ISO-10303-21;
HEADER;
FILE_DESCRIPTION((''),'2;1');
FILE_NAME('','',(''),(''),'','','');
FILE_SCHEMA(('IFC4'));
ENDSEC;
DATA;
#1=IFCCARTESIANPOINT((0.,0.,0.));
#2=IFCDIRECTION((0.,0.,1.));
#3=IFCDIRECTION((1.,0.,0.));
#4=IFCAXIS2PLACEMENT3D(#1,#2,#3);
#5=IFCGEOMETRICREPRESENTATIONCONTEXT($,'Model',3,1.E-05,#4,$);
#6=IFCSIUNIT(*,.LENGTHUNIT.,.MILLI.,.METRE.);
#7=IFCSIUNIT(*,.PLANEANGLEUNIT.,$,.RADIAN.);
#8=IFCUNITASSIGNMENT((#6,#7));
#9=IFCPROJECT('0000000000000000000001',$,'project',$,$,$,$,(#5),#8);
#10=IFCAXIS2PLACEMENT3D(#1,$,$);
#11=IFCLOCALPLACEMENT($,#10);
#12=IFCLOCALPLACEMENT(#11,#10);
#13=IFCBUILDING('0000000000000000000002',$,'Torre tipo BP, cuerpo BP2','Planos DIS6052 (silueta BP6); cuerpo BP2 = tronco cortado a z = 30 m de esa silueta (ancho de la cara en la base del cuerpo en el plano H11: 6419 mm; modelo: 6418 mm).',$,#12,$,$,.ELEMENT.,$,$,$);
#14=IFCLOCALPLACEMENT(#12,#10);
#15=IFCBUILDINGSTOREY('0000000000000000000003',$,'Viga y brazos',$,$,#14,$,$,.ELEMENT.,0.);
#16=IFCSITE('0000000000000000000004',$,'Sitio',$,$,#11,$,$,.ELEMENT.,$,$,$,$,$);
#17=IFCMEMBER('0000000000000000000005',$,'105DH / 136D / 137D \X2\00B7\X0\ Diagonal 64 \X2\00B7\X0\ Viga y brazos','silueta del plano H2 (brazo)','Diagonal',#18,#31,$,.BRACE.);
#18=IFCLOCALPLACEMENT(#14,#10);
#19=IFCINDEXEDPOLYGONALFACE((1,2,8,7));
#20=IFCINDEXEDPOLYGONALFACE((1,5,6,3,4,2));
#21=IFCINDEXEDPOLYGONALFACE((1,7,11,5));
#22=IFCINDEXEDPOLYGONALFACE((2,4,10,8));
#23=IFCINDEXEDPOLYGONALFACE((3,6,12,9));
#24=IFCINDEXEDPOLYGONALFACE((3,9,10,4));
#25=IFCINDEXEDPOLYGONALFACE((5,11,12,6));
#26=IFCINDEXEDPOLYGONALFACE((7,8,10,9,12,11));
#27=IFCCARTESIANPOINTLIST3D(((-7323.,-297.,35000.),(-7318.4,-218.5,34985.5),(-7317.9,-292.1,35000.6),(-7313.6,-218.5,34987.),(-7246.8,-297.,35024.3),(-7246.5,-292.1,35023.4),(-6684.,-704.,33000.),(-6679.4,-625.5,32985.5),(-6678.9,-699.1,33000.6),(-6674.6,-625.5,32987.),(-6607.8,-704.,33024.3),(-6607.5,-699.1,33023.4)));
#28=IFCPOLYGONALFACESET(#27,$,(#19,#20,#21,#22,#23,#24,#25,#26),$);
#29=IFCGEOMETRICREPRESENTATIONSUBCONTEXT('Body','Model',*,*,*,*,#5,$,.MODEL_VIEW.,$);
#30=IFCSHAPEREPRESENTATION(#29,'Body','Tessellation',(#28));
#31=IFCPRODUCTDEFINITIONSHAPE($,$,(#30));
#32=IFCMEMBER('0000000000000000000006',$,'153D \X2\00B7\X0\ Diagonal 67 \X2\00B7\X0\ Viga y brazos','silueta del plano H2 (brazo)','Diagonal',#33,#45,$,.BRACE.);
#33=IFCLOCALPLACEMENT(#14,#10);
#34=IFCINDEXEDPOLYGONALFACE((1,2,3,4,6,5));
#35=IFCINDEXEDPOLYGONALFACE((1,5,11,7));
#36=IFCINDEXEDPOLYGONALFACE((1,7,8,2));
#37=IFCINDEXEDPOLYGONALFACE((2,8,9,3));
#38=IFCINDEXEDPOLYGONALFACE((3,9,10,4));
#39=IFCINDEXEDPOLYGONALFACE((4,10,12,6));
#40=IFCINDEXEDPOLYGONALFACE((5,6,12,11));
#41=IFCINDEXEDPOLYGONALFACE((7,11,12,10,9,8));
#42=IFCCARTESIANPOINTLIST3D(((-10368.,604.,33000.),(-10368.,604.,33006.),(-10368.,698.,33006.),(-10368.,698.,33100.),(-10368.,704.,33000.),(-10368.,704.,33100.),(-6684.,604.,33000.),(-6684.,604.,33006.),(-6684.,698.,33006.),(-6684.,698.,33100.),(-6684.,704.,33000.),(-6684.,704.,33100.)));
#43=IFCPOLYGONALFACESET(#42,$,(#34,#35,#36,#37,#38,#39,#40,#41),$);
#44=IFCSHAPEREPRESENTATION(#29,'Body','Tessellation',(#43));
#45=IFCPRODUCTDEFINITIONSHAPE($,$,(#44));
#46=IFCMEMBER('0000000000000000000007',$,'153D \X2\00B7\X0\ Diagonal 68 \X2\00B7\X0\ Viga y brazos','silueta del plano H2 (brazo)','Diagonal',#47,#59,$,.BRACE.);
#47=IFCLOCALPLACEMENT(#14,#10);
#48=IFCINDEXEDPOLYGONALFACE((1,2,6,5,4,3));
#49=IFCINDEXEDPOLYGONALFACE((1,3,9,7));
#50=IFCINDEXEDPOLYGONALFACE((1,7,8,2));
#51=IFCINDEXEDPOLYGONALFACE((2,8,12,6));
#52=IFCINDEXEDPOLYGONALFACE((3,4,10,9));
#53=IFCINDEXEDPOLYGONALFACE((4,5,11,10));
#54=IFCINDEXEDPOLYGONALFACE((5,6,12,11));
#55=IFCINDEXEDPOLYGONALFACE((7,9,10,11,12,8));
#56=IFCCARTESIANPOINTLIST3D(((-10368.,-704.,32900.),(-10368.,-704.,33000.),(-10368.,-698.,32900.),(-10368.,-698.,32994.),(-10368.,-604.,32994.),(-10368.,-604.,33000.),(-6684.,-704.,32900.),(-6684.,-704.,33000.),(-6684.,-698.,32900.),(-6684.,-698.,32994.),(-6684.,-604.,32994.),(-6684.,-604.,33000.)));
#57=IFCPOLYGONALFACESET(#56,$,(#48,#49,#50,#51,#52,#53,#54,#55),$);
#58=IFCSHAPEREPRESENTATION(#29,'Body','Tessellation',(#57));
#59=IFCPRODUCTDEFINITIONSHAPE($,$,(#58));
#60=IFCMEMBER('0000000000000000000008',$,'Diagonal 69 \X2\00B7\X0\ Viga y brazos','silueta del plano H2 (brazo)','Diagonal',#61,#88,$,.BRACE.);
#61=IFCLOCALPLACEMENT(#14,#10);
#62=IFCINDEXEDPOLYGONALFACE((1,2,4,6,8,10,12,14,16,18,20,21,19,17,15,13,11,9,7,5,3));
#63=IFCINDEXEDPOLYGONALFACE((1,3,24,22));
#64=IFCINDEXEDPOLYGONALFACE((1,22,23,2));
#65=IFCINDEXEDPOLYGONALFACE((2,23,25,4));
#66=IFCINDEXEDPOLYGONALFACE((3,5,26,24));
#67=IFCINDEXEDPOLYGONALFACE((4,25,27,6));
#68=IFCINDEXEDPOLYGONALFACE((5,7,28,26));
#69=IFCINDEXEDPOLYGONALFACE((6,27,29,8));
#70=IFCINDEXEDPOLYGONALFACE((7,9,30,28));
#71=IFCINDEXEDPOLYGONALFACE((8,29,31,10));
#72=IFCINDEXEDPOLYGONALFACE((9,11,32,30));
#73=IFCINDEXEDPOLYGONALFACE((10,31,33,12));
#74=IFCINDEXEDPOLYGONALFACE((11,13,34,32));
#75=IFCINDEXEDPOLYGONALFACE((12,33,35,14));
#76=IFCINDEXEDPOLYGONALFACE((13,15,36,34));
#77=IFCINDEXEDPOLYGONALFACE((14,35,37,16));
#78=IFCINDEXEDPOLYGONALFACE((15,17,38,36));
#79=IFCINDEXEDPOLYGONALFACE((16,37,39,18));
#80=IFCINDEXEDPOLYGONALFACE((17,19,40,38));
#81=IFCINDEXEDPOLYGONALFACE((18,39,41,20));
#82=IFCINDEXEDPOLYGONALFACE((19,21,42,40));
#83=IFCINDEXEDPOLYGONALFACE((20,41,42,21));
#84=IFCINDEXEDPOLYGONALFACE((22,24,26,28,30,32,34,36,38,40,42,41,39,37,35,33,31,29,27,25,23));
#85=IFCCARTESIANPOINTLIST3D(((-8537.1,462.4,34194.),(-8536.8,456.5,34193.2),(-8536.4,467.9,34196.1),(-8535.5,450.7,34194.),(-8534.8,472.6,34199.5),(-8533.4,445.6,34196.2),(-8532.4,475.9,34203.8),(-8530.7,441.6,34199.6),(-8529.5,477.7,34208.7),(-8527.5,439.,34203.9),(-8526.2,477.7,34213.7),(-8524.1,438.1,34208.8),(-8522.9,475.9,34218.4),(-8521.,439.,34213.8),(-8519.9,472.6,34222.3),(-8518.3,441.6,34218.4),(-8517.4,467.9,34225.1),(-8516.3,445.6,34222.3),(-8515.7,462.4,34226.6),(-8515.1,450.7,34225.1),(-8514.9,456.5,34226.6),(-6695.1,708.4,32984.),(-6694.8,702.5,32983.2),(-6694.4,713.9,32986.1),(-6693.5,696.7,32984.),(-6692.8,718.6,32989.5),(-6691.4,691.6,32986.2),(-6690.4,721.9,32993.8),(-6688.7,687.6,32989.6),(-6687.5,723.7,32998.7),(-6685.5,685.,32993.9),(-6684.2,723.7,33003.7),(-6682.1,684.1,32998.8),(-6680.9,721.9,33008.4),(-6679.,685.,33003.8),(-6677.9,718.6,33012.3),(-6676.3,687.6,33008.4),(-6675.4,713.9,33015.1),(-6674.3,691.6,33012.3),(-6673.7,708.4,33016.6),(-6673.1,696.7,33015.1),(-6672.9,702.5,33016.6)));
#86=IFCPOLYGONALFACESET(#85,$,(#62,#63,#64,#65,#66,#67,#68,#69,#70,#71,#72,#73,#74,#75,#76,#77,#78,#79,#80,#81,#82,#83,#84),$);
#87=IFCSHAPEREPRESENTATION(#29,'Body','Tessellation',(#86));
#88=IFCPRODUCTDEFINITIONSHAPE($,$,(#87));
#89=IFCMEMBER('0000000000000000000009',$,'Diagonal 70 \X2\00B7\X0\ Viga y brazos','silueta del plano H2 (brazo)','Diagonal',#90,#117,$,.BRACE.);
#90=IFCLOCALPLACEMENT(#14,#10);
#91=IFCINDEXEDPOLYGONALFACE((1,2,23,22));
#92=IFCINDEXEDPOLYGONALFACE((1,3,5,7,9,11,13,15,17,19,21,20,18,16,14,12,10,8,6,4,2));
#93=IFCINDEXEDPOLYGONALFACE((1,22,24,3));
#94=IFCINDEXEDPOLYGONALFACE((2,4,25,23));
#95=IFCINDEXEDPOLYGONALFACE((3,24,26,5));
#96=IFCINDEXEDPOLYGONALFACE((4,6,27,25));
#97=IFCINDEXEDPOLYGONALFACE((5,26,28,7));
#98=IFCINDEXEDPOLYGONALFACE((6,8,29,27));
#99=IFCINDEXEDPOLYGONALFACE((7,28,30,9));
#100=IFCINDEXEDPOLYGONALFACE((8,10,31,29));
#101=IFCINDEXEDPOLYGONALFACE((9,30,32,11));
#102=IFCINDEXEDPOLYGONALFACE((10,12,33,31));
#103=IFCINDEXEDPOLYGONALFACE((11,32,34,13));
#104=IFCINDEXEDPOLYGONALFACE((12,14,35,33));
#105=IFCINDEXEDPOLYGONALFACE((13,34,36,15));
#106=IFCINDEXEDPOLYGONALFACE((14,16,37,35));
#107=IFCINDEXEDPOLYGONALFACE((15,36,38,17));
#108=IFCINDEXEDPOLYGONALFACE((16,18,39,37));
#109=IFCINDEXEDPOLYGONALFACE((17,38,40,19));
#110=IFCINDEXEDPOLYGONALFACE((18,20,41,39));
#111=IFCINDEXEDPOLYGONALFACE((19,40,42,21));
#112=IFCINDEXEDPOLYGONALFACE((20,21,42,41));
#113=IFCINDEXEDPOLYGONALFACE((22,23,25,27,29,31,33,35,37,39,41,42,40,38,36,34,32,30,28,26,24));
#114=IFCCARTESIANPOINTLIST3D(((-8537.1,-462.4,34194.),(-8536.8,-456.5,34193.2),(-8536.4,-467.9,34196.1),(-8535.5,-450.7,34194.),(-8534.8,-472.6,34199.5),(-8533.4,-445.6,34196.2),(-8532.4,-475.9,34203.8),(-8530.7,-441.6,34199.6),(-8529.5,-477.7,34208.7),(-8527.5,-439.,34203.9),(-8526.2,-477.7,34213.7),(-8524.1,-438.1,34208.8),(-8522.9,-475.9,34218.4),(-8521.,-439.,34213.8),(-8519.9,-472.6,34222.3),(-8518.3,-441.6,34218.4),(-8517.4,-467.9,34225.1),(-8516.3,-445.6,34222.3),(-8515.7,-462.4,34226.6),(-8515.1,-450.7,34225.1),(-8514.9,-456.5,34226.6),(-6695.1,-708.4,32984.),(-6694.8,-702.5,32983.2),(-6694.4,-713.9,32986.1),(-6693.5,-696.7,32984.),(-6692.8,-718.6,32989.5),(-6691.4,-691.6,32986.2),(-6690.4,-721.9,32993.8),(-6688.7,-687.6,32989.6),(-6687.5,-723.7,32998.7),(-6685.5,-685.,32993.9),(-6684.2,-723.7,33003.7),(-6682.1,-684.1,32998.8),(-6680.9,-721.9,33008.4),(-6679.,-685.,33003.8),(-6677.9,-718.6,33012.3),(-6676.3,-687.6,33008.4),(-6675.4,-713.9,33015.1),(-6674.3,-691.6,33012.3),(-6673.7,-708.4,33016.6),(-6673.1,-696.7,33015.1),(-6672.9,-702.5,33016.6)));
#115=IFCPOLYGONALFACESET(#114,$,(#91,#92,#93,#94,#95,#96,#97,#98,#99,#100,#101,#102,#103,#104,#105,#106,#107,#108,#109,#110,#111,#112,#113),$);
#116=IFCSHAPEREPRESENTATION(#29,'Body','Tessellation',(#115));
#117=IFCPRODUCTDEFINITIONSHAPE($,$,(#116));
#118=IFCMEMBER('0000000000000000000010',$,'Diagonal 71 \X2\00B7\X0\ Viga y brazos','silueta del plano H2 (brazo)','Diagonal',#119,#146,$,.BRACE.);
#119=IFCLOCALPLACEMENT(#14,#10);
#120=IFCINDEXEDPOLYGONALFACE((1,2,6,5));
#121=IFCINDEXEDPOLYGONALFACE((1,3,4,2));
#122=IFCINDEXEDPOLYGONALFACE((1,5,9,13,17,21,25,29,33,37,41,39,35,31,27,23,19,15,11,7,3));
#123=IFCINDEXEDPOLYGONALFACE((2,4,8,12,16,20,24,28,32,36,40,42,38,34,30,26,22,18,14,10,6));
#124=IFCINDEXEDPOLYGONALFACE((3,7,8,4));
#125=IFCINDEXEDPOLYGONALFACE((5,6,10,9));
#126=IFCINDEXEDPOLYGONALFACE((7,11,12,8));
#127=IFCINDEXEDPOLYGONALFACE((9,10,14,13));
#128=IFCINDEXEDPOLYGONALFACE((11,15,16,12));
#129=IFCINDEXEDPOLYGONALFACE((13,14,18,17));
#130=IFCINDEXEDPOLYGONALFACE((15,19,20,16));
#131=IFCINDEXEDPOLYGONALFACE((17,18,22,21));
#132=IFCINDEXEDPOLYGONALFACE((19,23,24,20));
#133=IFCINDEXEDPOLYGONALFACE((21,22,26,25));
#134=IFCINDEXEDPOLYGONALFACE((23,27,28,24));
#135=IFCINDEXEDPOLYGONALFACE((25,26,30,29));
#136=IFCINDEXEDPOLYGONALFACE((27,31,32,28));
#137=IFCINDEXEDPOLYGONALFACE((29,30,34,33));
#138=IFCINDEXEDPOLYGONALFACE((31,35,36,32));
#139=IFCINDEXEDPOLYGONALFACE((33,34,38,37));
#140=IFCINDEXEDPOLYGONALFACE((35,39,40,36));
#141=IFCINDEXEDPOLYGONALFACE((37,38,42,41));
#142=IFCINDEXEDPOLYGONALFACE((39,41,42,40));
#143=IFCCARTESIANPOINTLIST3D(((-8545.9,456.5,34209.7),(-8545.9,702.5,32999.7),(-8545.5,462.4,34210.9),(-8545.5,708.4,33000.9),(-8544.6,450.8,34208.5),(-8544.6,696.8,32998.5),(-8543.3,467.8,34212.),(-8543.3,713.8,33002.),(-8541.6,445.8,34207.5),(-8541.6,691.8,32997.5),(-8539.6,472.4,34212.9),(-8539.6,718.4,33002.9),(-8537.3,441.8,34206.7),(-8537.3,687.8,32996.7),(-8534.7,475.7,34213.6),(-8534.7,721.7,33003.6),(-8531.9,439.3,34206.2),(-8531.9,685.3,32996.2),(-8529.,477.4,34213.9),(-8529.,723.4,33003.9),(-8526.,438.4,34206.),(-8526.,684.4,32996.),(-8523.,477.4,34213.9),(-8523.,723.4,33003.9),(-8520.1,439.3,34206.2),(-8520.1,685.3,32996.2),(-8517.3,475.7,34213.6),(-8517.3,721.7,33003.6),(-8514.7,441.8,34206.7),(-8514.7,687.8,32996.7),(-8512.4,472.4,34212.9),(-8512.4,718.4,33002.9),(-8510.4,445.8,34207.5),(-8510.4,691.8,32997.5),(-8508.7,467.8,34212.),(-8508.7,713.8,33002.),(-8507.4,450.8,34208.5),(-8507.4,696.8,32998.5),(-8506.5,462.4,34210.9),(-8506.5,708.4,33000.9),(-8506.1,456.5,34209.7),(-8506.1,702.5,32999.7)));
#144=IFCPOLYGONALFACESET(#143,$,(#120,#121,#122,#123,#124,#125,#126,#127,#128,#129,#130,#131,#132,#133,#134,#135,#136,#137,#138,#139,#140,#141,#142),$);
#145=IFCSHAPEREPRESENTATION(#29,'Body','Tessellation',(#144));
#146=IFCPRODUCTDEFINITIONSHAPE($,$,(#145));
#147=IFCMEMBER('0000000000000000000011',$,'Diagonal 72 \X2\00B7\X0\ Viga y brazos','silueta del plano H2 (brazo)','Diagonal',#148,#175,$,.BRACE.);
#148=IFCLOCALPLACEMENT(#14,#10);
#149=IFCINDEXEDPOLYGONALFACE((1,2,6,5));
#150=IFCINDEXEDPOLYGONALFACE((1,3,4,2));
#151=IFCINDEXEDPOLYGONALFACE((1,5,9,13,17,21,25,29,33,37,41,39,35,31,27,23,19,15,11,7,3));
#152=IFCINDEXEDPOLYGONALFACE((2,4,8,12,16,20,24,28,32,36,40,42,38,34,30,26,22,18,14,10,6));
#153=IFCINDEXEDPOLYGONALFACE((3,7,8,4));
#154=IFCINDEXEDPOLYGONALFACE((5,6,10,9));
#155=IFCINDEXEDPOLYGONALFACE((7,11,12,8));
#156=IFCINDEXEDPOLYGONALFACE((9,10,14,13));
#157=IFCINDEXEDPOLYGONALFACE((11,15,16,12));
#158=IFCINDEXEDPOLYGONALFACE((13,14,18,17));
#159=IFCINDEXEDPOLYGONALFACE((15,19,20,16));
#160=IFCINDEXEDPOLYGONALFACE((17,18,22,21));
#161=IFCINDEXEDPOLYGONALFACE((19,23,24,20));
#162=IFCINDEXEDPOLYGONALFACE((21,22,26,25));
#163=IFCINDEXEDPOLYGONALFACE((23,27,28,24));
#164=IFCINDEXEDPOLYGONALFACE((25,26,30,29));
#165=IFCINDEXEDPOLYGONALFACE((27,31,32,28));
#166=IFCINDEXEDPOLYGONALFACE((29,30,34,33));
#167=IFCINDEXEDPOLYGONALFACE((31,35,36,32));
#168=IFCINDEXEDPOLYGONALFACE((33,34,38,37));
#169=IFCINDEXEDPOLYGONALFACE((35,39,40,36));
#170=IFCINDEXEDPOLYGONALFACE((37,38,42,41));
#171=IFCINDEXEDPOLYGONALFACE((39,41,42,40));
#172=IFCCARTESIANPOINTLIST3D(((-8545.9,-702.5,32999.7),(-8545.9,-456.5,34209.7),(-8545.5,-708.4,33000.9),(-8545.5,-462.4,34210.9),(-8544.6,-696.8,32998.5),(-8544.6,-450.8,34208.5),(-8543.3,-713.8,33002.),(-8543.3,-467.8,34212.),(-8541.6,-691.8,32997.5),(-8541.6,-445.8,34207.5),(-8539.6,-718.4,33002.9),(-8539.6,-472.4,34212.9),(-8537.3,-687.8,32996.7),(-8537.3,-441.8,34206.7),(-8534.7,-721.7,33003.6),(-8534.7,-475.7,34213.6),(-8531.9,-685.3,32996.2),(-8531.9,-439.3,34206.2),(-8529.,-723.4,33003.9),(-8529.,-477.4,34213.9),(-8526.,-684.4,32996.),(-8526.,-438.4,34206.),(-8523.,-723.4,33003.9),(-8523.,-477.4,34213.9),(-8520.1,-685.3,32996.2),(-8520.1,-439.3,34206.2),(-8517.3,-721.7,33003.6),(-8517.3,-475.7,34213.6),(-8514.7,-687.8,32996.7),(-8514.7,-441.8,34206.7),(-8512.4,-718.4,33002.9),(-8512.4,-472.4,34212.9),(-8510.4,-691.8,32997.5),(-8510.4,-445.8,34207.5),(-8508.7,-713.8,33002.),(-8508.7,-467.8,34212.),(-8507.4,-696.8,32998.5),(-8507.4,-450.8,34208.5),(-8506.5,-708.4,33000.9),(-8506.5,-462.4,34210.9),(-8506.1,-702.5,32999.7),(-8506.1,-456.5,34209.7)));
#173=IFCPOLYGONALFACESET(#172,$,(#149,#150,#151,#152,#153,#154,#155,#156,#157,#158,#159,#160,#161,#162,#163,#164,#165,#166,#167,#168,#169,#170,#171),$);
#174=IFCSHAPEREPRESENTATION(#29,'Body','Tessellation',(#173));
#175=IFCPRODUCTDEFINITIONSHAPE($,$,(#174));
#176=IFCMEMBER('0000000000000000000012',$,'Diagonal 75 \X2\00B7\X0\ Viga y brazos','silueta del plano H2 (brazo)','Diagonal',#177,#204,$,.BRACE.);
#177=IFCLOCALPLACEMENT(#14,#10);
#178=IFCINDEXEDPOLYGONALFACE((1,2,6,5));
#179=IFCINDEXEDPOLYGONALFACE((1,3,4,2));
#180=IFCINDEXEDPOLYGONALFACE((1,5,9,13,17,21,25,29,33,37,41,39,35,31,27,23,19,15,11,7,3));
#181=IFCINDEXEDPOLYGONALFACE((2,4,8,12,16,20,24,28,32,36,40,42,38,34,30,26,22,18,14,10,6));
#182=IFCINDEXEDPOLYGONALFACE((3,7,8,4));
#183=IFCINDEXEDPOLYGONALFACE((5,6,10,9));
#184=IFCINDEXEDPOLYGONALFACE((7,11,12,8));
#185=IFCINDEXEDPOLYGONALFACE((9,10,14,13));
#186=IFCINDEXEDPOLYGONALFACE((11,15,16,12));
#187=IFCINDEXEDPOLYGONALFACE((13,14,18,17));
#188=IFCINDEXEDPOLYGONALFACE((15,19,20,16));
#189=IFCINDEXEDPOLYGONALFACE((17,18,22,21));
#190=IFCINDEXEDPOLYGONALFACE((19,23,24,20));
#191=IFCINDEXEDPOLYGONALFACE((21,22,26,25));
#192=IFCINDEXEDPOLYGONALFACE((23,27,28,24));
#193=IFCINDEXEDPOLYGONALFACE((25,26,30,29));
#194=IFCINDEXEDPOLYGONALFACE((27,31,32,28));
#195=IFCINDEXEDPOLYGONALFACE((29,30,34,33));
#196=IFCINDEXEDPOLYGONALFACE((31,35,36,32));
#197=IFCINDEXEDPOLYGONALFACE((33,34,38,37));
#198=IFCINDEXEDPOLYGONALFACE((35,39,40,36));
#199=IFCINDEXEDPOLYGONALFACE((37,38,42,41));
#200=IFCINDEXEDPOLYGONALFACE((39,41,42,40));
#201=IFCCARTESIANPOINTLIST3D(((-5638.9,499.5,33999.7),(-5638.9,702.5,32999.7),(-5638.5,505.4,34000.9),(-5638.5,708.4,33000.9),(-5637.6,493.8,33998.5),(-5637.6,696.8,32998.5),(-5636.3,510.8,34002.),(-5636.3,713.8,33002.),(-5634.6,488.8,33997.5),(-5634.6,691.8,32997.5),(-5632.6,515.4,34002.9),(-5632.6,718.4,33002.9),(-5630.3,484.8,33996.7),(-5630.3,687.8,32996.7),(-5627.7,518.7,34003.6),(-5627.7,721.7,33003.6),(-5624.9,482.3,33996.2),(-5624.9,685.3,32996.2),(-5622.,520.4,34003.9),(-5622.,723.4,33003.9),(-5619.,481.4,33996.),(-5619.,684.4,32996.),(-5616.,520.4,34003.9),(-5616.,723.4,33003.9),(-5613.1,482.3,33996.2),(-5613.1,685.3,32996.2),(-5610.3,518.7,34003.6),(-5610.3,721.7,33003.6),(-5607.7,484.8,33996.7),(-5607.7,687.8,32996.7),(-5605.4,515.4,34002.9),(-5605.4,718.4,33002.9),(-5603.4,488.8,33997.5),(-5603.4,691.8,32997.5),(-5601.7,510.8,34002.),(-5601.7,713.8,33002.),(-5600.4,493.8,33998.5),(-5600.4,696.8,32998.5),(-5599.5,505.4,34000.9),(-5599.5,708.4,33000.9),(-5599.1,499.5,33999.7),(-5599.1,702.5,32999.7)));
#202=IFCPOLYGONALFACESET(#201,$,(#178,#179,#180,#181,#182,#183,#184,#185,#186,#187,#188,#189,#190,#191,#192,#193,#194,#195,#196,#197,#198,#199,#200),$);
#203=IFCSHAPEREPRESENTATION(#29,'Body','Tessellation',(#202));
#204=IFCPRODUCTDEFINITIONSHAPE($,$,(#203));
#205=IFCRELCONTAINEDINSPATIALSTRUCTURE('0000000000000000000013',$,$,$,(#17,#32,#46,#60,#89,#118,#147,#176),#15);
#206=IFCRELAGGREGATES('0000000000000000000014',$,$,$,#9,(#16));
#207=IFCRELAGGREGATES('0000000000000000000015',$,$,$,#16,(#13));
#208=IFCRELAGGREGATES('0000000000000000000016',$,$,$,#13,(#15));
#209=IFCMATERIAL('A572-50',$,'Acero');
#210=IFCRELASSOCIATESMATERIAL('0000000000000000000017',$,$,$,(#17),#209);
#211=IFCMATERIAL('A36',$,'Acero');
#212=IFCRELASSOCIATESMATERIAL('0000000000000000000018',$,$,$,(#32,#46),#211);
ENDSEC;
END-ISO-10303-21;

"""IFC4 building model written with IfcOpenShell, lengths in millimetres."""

from ifc_helpers import new_model, si_unit, frame, frame_2d, origin, origin_with_axes, place, context, subcontext, project, spatial, circle, l_section, extrude, material, element, save


model = new_model("IFC4")

# Units and contexts
model_context = context("Model", 3, precision=1e-05, world=origin_with_axes())
body_context = subcontext(model_context, "Body", "Model", "MODEL_VIEW")
ifc_project = project(units=[si_unit("LENGTHUNIT", "METRE", prefix="MILLI"), si_unit("PLANEANGLEUNIT", "RADIAN")], contexts=[model_context])

# Site, building, storey
site_placement = place(None, origin())
site = spatial("IfcSite", under=ifc_project, at=site_placement, Name="Sitio", CompositionType="ELEMENT")
building_placement = place(site_placement, origin())
building = spatial("IfcBuilding", under=site, at=building_placement, Name="Torre tipo BP, cuerpo BP2", Description="Planos DIS6052 (silueta BP6); cuerpo BP2 = tronco cortado a z = 30 m de esa silueta (ancho de la cara en la base del cuerpo en el plano H11: 6419 mm; modelo: 6418 mm).", CompositionType="ELEMENT")
storey_placement = place(building_placement, origin())
storey = spatial("IfcBuildingStorey", under=building, at=storey_placement, Name="Viga y brazos", CompositionType="ELEMENT", Elevation=0.0)

# Members
ifc_material_1 = material(Name="A36", Category="Acero")
ifc_material_2 = material(Name="A572-50", Category="Acero")
for number, where, z_axis, x_axis, name in (
    (1, (-7323.0, -297.0, 35000.0), (0.298782, -0.190304, -0.935154), (0.057918, 0.981725, -0.181276), "105DH / 136D / 137D · Diagonal 64 · Viga y brazos"),
):
    element("IfcMember", number, at=place(storey_placement, frame(where, z_axis=z_axis, x_axis=x_axis)), inside=storey, material=ifc_material_2, Name=name, Description="silueta del plano H2 (brazo)", ObjectType="Diagonal", PredefinedType="BRACE", context=body_context, shape_type="SweptSolid", body=[
        extrude(l_section(Depth=80.0, Width=80.0, Thickness=5.0, at=frame_2d((40.0, 40.0))), None, (0.0, 0.0, 1.0), 2138.7),
    ])
for number, where, z_axis, x_axis, name in (
    (2, (-6684.0, 704.0, 33000.0), (-1.0, 0.0, 0.0), (0.0, -1.0, 0.0), "153D · Diagonal 67 · Viga y brazos"),
    (3, (-6684.0, -704.0, 33000.0), (-1.0, 0.0, 0.0), (0.0, 1.0, 0.0), "153D · Diagonal 68 · Viga y brazos"),
):
    element("IfcMember", number, at=place(storey_placement, frame(where, z_axis=z_axis, x_axis=x_axis)), inside=storey, material=ifc_material_1, Name=name, Description="silueta del plano H2 (brazo)", ObjectType="Diagonal", PredefinedType="BRACE", context=body_context, shape_type="SweptSolid", body=[
        extrude(l_section(Depth=100.0, Width=100.0, Thickness=6.0, at=frame_2d((50.0, 50.0))), None, (0.0, 0.0, 1.0), 3684.0),
    ])
for number, where, z_axis, x_axis, name in (
    (4, (-6684.0, 704.0, 33000.0), (-0.830642, -0.110933, 0.545644), (0.092718, -0.993828, -0.060906), "Diagonal 69 · Viga y brazos"),
    (5, (-6684.0, -704.0, 33000.0), (-0.830642, 0.110933, 0.545644), (0.092718, 0.993828, -0.060906), "Diagonal 70 · Viga y brazos"),
):
    element("IfcMember", number, at=place(storey_placement, frame(where, z_axis=z_axis, x_axis=x_axis)), inside=storey, Name=name, Description="silueta del plano H2 (brazo)", ObjectType="Diagonal", PredefinedType="BRACE", context=body_context, shape_type="SweptSolid", body=[
        extrude(circle(Radius=20.0), None, (0.0, 0.0, 1.0), 2217.6),
    ])
for number, where, z_axis, x_axis, name in (
    (6, (-8526.0, 458.0, 34210.0), (0.0, 0.19923, -0.979953), (0.0, -0.979953, -0.19923), "Diagonal 71 · Viga y brazos"),
    (7, (-8526.0, -458.0, 34210.0), (0.0, -0.19923, -0.979953), (0.0, 0.979953, -0.19923), "Diagonal 72 · Viga y brazos"),
):
    element("IfcMember", number, at=place(storey_placement, frame(where, z_axis=z_axis, x_axis=x_axis)), inside=storey, Name=name, Description="silueta del plano H2 (brazo)", ObjectType="Diagonal", PredefinedType="BRACE", context=body_context, shape_type="SweptSolid", body=[
        extrude(circle(Radius=20.0), None, (0.0, 0.0, 1.0), 1234.8),
    ])
for number, where, z_axis, x_axis, name in (
    (8, (-5619.0, 704.0, 33000.0), (0.0, -0.198942, 0.980011), (0.0, -0.980011, -0.198942), "Diagonal 75 · Viga y brazos"),
):
    element("IfcMember", number, at=place(storey_placement, frame(where, z_axis=z_axis, x_axis=x_axis)), inside=storey, Name=name, Description="silueta del plano H2 (brazo)", ObjectType="Diagonal", PredefinedType="BRACE", context=body_context, shape_type="SweptSolid", body=[
        extrude(circle(Radius=20.0), None, (0.0, 0.0, 1.0), 1020.4),
    ])

save(model, "model.ifc")
